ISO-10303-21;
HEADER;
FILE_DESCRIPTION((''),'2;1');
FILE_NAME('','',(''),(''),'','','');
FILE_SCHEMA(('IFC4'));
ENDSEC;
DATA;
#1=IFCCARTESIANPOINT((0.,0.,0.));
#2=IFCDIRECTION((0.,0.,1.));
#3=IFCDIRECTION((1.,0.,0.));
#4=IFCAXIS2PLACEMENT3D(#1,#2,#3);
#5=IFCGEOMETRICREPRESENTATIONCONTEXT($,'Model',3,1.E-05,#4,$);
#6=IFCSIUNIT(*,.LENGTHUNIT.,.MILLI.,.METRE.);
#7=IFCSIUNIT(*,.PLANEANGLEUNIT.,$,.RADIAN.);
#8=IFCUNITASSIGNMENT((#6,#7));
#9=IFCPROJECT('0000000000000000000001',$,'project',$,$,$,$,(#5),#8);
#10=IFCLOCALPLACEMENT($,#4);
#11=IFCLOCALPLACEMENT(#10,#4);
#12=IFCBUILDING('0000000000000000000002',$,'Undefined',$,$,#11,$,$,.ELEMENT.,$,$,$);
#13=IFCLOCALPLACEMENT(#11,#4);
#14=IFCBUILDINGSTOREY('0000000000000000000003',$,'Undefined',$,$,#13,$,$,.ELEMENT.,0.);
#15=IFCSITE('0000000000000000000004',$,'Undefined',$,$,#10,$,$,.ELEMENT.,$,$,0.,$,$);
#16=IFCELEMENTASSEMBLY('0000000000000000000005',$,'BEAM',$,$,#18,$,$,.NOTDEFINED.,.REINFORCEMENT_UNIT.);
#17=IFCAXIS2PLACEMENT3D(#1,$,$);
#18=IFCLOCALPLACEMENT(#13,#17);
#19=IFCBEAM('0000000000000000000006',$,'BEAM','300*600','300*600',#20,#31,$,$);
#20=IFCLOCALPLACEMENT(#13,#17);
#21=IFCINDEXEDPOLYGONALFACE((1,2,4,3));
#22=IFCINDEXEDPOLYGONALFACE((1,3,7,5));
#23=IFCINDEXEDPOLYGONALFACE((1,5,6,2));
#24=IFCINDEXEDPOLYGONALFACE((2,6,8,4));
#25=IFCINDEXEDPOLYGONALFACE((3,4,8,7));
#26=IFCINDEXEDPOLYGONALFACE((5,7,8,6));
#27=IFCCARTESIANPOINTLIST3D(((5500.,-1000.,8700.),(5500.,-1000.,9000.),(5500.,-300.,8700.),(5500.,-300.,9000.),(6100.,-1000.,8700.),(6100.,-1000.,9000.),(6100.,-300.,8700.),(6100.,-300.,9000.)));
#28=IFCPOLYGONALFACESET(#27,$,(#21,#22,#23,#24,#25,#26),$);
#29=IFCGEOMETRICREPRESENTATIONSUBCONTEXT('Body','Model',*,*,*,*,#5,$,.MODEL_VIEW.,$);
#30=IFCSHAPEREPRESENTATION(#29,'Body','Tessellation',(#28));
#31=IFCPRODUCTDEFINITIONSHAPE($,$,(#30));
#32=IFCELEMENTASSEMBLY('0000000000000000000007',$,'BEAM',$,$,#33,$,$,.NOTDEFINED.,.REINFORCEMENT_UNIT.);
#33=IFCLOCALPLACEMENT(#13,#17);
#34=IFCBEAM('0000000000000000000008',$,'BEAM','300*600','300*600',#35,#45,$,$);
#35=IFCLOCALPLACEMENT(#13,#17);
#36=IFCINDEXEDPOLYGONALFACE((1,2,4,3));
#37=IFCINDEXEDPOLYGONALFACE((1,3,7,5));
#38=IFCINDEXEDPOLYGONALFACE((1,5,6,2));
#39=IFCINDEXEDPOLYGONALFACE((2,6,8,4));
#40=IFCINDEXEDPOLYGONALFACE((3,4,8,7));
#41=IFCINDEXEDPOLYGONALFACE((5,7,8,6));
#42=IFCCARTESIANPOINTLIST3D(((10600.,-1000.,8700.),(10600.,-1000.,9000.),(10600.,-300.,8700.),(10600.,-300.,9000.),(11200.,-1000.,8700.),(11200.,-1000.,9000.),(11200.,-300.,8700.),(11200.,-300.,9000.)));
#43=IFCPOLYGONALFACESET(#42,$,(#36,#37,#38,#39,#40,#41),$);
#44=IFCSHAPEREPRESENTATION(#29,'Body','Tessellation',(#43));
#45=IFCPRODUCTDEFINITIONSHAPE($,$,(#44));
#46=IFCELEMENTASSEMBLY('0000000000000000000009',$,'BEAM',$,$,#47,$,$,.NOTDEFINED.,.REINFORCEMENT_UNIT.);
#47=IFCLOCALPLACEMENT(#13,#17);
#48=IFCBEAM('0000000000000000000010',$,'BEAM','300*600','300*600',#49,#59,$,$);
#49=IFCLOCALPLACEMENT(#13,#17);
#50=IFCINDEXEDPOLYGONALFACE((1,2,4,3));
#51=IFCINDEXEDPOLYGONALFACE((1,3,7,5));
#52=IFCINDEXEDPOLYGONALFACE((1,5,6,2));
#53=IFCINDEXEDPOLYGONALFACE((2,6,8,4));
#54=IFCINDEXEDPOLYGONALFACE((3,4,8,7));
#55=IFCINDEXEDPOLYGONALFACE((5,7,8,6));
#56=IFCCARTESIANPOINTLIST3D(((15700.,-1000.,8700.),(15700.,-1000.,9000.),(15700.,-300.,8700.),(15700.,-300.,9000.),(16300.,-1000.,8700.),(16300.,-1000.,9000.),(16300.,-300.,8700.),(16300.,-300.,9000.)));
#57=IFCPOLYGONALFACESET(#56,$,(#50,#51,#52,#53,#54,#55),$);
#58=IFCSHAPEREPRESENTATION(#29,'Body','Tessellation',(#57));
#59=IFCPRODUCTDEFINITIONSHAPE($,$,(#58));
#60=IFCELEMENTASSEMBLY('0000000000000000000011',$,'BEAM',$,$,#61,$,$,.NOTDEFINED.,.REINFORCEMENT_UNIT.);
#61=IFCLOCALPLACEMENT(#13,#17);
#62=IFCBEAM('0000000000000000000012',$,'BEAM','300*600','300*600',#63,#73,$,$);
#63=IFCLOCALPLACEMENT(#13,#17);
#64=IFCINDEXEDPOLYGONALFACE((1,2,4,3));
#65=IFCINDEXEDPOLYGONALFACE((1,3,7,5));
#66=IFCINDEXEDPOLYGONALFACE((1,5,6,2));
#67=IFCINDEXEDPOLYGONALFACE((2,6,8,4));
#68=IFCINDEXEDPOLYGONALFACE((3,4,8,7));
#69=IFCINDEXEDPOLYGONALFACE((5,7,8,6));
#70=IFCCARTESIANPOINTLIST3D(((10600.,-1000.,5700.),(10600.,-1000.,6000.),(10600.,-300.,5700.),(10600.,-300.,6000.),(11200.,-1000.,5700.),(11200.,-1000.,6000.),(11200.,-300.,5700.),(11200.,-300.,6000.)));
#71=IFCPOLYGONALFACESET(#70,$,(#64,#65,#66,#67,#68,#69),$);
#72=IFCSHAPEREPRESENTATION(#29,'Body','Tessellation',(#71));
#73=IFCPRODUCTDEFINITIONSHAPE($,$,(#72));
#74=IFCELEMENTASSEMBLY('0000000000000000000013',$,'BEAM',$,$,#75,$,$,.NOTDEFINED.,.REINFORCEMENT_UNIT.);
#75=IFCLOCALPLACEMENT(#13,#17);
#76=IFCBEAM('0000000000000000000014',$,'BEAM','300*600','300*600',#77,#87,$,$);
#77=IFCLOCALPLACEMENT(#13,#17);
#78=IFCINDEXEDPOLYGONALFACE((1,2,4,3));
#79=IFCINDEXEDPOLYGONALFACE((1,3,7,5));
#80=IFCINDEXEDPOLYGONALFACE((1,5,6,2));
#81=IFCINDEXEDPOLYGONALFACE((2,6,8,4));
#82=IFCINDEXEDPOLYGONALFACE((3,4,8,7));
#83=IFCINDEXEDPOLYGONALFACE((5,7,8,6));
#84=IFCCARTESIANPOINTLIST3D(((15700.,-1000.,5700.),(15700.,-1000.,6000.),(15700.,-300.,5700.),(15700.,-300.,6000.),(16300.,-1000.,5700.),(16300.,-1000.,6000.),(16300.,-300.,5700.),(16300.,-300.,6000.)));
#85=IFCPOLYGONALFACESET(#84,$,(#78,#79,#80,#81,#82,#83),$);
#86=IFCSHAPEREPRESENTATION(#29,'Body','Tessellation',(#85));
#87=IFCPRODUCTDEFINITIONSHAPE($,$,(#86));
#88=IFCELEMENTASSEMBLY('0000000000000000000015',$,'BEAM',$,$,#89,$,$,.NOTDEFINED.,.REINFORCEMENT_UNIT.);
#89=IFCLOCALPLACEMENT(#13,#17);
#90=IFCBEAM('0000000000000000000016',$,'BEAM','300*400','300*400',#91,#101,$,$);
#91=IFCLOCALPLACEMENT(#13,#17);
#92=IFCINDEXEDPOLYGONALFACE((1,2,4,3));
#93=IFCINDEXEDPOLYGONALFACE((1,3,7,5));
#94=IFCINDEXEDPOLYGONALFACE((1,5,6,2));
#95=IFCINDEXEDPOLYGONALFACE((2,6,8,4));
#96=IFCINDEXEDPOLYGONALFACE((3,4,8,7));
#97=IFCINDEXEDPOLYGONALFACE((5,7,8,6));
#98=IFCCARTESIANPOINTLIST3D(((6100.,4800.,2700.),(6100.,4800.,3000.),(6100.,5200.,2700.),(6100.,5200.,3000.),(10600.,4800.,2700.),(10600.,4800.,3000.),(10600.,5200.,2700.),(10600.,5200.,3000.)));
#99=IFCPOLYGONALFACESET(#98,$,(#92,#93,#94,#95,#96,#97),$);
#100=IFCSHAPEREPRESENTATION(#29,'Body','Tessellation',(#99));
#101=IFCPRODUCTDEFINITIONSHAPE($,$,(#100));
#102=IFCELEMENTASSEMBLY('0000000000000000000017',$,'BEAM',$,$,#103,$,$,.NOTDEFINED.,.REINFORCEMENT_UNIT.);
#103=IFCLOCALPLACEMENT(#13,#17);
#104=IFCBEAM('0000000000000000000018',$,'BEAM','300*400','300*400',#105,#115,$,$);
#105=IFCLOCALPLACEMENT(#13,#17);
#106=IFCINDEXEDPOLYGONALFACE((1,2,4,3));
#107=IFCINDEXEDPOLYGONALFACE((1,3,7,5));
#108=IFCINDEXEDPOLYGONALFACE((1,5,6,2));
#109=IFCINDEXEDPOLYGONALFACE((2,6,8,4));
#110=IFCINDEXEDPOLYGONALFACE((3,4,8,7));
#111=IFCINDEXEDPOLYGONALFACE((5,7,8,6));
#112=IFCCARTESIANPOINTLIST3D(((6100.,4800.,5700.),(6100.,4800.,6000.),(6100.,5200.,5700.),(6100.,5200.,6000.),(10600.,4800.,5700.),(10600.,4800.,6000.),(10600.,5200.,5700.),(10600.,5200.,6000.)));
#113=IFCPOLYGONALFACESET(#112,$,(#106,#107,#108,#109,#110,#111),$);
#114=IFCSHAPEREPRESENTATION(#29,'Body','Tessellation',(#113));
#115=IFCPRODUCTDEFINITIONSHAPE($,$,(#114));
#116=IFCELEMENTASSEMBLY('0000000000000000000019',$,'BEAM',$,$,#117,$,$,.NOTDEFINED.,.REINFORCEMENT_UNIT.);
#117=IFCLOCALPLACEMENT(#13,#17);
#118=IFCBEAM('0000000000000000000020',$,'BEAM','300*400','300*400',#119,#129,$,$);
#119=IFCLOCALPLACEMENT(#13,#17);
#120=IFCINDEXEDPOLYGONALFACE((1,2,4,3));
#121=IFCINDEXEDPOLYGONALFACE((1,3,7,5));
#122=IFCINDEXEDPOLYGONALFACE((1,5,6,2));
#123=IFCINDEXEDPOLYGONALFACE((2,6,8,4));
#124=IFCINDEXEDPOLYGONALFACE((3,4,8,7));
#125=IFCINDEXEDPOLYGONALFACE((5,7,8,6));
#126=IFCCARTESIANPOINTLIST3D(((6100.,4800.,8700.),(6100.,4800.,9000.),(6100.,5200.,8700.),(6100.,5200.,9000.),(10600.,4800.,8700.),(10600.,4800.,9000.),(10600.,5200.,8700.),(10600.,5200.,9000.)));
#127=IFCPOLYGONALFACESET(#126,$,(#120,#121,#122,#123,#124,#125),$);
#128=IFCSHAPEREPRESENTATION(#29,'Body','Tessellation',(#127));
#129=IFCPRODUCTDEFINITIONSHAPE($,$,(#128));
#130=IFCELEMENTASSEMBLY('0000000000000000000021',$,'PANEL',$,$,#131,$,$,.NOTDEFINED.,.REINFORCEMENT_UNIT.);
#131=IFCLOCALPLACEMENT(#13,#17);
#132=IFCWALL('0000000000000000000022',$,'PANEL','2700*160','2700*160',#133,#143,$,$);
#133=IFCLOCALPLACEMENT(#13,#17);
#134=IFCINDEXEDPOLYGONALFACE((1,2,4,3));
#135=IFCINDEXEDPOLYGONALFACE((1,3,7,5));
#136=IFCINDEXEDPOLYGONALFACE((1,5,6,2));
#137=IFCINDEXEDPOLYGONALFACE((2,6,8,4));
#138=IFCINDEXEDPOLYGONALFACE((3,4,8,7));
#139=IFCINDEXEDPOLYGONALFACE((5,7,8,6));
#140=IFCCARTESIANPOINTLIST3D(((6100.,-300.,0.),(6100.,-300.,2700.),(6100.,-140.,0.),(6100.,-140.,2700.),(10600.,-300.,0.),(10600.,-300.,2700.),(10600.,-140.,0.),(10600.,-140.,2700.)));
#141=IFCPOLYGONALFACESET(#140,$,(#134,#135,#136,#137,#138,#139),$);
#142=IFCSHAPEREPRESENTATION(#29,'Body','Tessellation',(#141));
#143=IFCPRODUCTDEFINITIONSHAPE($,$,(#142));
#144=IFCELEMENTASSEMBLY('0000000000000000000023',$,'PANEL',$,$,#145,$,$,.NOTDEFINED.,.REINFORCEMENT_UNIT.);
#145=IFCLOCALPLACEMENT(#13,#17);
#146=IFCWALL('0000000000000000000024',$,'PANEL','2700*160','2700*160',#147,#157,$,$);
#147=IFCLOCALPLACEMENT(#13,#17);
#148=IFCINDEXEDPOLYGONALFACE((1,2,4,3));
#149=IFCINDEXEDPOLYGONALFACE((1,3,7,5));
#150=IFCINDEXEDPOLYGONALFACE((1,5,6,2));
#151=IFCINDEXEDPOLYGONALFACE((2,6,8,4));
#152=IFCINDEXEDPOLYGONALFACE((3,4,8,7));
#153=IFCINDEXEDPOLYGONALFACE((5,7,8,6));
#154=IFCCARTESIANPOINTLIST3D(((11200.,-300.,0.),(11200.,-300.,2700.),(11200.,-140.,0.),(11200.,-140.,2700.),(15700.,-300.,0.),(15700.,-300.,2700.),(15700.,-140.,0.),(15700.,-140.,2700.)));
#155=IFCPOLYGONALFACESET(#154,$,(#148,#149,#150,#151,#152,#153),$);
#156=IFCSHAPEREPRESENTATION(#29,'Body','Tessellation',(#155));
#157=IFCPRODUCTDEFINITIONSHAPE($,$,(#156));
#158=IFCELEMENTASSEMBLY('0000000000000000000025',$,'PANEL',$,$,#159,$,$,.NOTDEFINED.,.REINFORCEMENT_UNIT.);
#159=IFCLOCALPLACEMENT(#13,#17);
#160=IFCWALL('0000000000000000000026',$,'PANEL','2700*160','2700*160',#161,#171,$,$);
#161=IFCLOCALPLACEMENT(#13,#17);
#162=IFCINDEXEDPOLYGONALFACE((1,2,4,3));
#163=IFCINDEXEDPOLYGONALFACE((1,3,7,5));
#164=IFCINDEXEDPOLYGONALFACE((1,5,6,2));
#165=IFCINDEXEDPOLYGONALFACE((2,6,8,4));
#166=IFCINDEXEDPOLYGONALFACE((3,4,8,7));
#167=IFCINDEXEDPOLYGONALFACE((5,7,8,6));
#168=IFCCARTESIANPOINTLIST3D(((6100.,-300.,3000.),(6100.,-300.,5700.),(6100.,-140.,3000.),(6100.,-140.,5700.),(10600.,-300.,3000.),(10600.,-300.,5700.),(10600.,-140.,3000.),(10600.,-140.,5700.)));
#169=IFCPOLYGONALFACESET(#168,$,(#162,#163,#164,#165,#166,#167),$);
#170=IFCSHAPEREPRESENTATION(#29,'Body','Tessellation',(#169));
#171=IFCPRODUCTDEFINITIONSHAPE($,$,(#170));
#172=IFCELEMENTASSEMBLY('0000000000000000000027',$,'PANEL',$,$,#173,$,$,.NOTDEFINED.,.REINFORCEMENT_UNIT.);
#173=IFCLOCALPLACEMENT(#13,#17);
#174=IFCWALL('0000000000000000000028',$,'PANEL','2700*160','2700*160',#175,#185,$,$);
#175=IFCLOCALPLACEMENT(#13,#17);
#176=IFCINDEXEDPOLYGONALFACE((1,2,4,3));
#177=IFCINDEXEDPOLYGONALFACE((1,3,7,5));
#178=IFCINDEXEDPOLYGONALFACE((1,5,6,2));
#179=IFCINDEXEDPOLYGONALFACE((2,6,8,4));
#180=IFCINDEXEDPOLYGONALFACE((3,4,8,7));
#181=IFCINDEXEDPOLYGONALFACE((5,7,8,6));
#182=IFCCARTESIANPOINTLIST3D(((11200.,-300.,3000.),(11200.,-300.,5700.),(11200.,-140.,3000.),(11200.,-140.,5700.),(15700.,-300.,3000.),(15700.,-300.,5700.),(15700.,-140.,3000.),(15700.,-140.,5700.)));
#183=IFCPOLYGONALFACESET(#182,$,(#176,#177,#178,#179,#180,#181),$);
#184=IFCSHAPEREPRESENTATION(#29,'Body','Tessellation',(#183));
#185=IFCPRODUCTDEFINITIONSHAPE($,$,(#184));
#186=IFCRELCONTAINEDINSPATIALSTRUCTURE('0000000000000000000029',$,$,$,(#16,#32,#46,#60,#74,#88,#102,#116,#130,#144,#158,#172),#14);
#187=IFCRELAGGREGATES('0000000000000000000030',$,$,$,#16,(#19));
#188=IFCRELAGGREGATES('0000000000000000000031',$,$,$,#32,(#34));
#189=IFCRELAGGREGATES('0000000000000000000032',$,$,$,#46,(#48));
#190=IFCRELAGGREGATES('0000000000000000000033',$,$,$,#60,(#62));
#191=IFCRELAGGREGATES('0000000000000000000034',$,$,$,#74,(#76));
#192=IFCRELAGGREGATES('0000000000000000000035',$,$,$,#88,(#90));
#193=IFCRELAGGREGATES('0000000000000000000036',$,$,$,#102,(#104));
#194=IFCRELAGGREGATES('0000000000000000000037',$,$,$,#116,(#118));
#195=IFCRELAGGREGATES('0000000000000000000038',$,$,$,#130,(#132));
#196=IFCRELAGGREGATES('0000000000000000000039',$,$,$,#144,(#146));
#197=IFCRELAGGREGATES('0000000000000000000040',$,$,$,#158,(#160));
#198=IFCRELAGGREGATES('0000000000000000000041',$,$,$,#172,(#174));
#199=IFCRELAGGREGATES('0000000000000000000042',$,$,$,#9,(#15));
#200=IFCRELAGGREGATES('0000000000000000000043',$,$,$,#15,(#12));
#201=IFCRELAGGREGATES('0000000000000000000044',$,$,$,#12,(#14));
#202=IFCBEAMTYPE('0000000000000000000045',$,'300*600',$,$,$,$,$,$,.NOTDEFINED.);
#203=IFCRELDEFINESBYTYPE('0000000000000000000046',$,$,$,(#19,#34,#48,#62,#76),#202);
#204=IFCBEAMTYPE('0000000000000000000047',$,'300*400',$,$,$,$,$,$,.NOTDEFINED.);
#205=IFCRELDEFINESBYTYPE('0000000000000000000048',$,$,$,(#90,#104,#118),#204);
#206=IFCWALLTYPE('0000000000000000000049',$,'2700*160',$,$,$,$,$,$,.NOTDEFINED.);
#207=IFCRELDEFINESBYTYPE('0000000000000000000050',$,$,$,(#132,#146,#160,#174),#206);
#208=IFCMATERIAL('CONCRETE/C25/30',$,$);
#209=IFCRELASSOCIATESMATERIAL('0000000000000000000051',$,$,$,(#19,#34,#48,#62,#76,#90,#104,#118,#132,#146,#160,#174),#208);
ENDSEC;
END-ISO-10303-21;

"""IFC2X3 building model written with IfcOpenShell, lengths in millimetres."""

from ifc_helpers import new_model, si_unit, frame, frame_2d, origin_with_axes, origin_2d_with_axis, place, context, subcontext, project, spatial, rectangle, extrude, material, type_object, element, aggregate, save


model = new_model("IFC2X3")

# Units and contexts
model_context = context("Model", 3, precision=1e-05, world=origin_with_axes())
body_context = subcontext(model_context, "Body", "Model", "MODEL_VIEW")
ifc_project = project(units=[si_unit("LENGTHUNIT", "METRE", prefix="MILLI"), si_unit("PLANEANGLEUNIT", "RADIAN")], contexts=[model_context])

# Site, building, storey
site_placement = place(None, origin_with_axes())
site = spatial("IfcSite", under=ifc_project, at=site_placement, Name="Undefined", CompositionType="ELEMENT", RefElevation=0.0)
building_placement = place(site_placement, origin_with_axes())
building = spatial("IfcBuilding", under=site, at=building_placement, Name="Undefined", CompositionType="ELEMENT")
storey_placement = place(building_placement, origin_with_axes())
storey = spatial("IfcBuildingStorey", under=building, at=storey_placement, Name="Undefined", CompositionType="ELEMENT", Elevation=0.0)

# Shared definitions
ifc_material = material(Name="CONCRETE/C25/30")

# Element assemblies, beams
beam_type_1 = type_object("IfcBeamType", Name="300*600", PredefinedType="NOTDEFINED")
assembly_1_placement = place(storey_placement, origin_with_axes())
assembly_1 = element("IfcElementAssembly", 1, at=assembly_1_placement, inside=storey, Name="BEAM", AssemblyPlace="NOTDEFINED", PredefinedType="REINFORCEMENT_UNIT")
beam_1_placement = place(assembly_1_placement, frame((5800.0, -300.0, 8850.0), z_axis=(0.0, 0.0, 1.0), x_axis=(0.0, -1.0, 0.0)))
beam_1 = element("IfcBeam", 2, at=beam_1_placement, type_object=beam_type_1, material=ifc_material, Name="BEAM", Description="300*600", ObjectType="300*600", context=body_context, shape_type="SweptSolid", body=[
    extrude(rectangle(XDim=600.0, YDim=300.0, at=origin_2d_with_axis()), frame((700.0, 0.0, 0.0), z_axis=(-1.0, 0.0, 0.0), x_axis=(0.0, -1.0, 0.0)), (0.0, 0.0, 1.0), 700.0),
])
aggregate(assembly_1, [beam_1])
assembly_2_placement = place(storey_placement, origin_with_axes())
assembly_2 = element("IfcElementAssembly", 3, at=assembly_2_placement, inside=storey, Name="BEAM", AssemblyPlace="NOTDEFINED", PredefinedType="REINFORCEMENT_UNIT")
beam_2_placement = place(assembly_2_placement, frame((10900.0, -300.0, 8850.0), z_axis=(0.0, 0.0, 1.0), x_axis=(0.0, -1.0, 0.0)))
beam_2 = element("IfcBeam", 4, at=beam_2_placement, type_object=beam_type_1, material=ifc_material, Name="BEAM", Description="300*600", ObjectType="300*600", context=body_context, shape_type="SweptSolid", body=[
    extrude(rectangle(XDim=600.0, YDim=300.0, at=origin_2d_with_axis()), frame((700.0, 0.0, 0.0), z_axis=(-1.0, 0.0, 0.0), x_axis=(0.0, -1.0, 0.0)), (0.0, 0.0, 1.0), 700.0),
])
aggregate(assembly_2, [beam_2])
assembly_3_placement = place(storey_placement, origin_with_axes())
assembly_3 = element("IfcElementAssembly", 5, at=assembly_3_placement, inside=storey, Name="BEAM", AssemblyPlace="NOTDEFINED", PredefinedType="REINFORCEMENT_UNIT")
beam_3_placement = place(assembly_3_placement, frame((16000.0, -300.0, 8850.0), z_axis=(0.0, 0.0, 1.0), x_axis=(0.0, -1.0, 0.0)))
beam_3 = element("IfcBeam", 6, at=beam_3_placement, type_object=beam_type_1, material=ifc_material, Name="BEAM", Description="300*600", ObjectType="300*600", context=body_context, shape_type="SweptSolid", body=[
    extrude(rectangle(XDim=600.0, YDim=300.0, at=origin_2d_with_axis()), frame((700.0, 0.0, 0.0), z_axis=(-1.0, 0.0, 0.0), x_axis=(0.0, -1.0, 0.0)), (0.0, 0.0, 1.0), 700.0),
])
aggregate(assembly_3, [beam_3])
assembly_4_placement = place(storey_placement, origin_with_axes())
assembly_4 = element("IfcElementAssembly", 7, at=assembly_4_placement, inside=storey, Name="BEAM", AssemblyPlace="NOTDEFINED", PredefinedType="REINFORCEMENT_UNIT")
beam_4_placement = place(assembly_4_placement, frame((10900.0, -300.0, 5850.0), z_axis=(0.0, 0.0, 1.0), x_axis=(0.0, -1.0, 0.0)))
beam_4 = element("IfcBeam", 8, at=beam_4_placement, type_object=beam_type_1, material=ifc_material, Name="BEAM", Description="300*600", ObjectType="300*600", context=body_context, shape_type="SweptSolid", body=[
    extrude(rectangle(XDim=600.0, YDim=300.0, at=origin_2d_with_axis()), frame((700.0, 0.0, 0.0), z_axis=(-1.0, 0.0, 0.0), x_axis=(0.0, -1.0, 0.0)), (0.0, 0.0, 1.0), 700.0),
])
aggregate(assembly_4, [beam_4])
assembly_5_placement = place(storey_placement, origin_with_axes())
assembly_5 = element("IfcElementAssembly", 9, at=assembly_5_placement, inside=storey, Name="BEAM", AssemblyPlace="NOTDEFINED", PredefinedType="REINFORCEMENT_UNIT")
beam_5_placement = place(assembly_5_placement, frame((16000.0, -300.0, 5850.0), z_axis=(0.0, 0.0, 1.0), x_axis=(0.0, -1.0, 0.0)))
beam_5 = element("IfcBeam", 10, at=beam_5_placement, type_object=beam_type_1, material=ifc_material, Name="BEAM", Description="300*600", ObjectType="300*600", context=body_context, shape_type="SweptSolid", body=[
    extrude(rectangle(XDim=600.0, YDim=300.0, at=origin_2d_with_axis()), frame((700.0, 0.0, 0.0), z_axis=(-1.0, 0.0, 0.0), x_axis=(0.0, -1.0, 0.0)), (0.0, 0.0, 1.0), 700.0),
])
aggregate(assembly_5, [beam_5])
assembly_6_placement = place(storey_placement, origin_with_axes())
assembly_6 = element("IfcElementAssembly", 11, at=assembly_6_placement, inside=storey, Name="BEAM", AssemblyPlace="NOTDEFINED", PredefinedType="REINFORCEMENT_UNIT")
beam_type_2 = type_object("IfcBeamType", Name="300*400", PredefinedType="NOTDEFINED")
beam_6_placement = place(assembly_6_placement, frame((10900.0, 5000.0, 2850.0), z_axis=(0.0, 0.0, 1.0), x_axis=(-1.0, 0.0, 0.0)))
beam_6 = element("IfcBeam", 12, at=beam_6_placement, type_object=beam_type_2, material=ifc_material, Name="BEAM", Description="300*400", ObjectType="300*400", context=body_context, shape_type="SweptSolid", body=[
    extrude(rectangle(XDim=400.0, YDim=300.0, at=origin_2d_with_axis()), frame((4800.0, 0.0, 0.0), z_axis=(-1.0, 0.0, 0.0), x_axis=(0.0, -1.0, 0.0)), (0.0, 0.0, 1.0), 4500.0),
])
aggregate(assembly_6, [beam_6])
assembly_7_placement = place(storey_placement, origin_with_axes())
assembly_7 = element("IfcElementAssembly", 13, at=assembly_7_placement, inside=storey, Name="BEAM", AssemblyPlace="NOTDEFINED", PredefinedType="REINFORCEMENT_UNIT")
beam_7_placement = place(assembly_7_placement, frame((10900.0, 5000.0, 5850.0), z_axis=(0.0, 0.0, 1.0), x_axis=(-1.0, 0.0, 0.0)))
beam_7 = element("IfcBeam", 14, at=beam_7_placement, type_object=beam_type_2, material=ifc_material, Name="BEAM", Description="300*400", ObjectType="300*400", context=body_context, shape_type="SweptSolid", body=[
    extrude(rectangle(XDim=400.0, YDim=300.0, at=origin_2d_with_axis()), frame((4800.0, 0.0, 0.0), z_axis=(-1.0, 0.0, 0.0), x_axis=(0.0, -1.0, 0.0)), (0.0, 0.0, 1.0), 4500.0),
])
aggregate(assembly_7, [beam_7])
assembly_8_placement = place(storey_placement, origin_with_axes())
assembly_8 = element("IfcElementAssembly", 15, at=assembly_8_placement, inside=storey, Name="BEAM", AssemblyPlace="NOTDEFINED", PredefinedType="REINFORCEMENT_UNIT")
beam_8_placement = place(assembly_8_placement, frame((10900.0, 5000.0, 8850.0), z_axis=(0.0, 0.0, 1.0), x_axis=(-1.0, 0.0, 0.0)))
beam_8 = element("IfcBeam", 16, at=beam_8_placement, type_object=beam_type_2, material=ifc_material, Name="BEAM", Description="300*400", ObjectType="300*400", context=body_context, shape_type="SweptSolid", body=[
    extrude(rectangle(XDim=400.0, YDim=300.0, at=origin_2d_with_axis()), frame((4800.0, 0.0, 0.0), z_axis=(-1.0, 0.0, 0.0), x_axis=(0.0, -1.0, 0.0)), (0.0, 0.0, 1.0), 4500.0),
])
aggregate(assembly_8, [beam_8])

# Element assemblies, walls
assembly_9_placement = place(storey_placement, origin_with_axes())
assembly_9 = element("IfcElementAssembly", 17, at=assembly_9_placement, inside=storey, Name="PANEL", AssemblyPlace="NOTDEFINED", PredefinedType="REINFORCEMENT_UNIT")
wall_type = type_object("IfcWallType", Name="2700*160", PredefinedType="NOTDEFINED")
wall_1_placement = place(assembly_9_placement, frame((6100.0, -220.0, 0.0), z_axis=(0.0, 0.0, 1.0), x_axis=(1.0, 0.0, 0.0)))
wall_1 = element("IfcWall", 18, at=wall_1_placement, type_object=wall_type, material=ifc_material, Name="PANEL", Description="2700*160", ObjectType="2700*160", context=body_context, shape_type="SweptSolid", body=[
    extrude(rectangle(XDim=4500.0, YDim=160.0, at=frame_2d((0.0, 2250.0), x_axis=(0.0, -1.0))), frame((0.0, 0.0, 0.0), z_axis=(0.0, 0.0, 1.0), x_axis=(0.0, -1.0, 0.0)), (0.0, 0.0, 1.0), 2700.0),
])
aggregate(assembly_9, [wall_1])
assembly_10_placement = place(storey_placement, origin_with_axes())
assembly_10 = element("IfcElementAssembly", 19, at=assembly_10_placement, inside=storey, Name="PANEL", AssemblyPlace="NOTDEFINED", PredefinedType="REINFORCEMENT_UNIT")
wall_2_placement = place(assembly_10_placement, frame((11200.0, -220.0, 0.0), z_axis=(0.0, 0.0, 1.0), x_axis=(1.0, 0.0, 0.0)))
wall_2 = element("IfcWall", 20, at=wall_2_placement, type_object=wall_type, material=ifc_material, Name="PANEL", Description="2700*160", ObjectType="2700*160", context=body_context, shape_type="SweptSolid", body=[
    extrude(rectangle(XDim=4500.0, YDim=160.0, at=frame_2d((0.0, 2250.0), x_axis=(0.0, -1.0))), frame((0.0, 0.0, 0.0), z_axis=(0.0, 0.0, 1.0), x_axis=(0.0, -1.0, 0.0)), (0.0, 0.0, 1.0), 2700.0),
])
aggregate(assembly_10, [wall_2])
assembly_11_placement = place(storey_placement, origin_with_axes())
assembly_11 = element("IfcElementAssembly", 21, at=assembly_11_placement, inside=storey, Name="PANEL", AssemblyPlace="NOTDEFINED", PredefinedType="REINFORCEMENT_UNIT")
wall_3_placement = place(assembly_11_placement, frame((6100.0, -220.0, 3000.0), z_axis=(0.0, 0.0, 1.0), x_axis=(1.0, 0.0, 0.0)))
wall_3 = element("IfcWall", 22, at=wall_3_placement, type_object=wall_type, material=ifc_material, Name="PANEL", Description="2700*160", ObjectType="2700*160", context=body_context, shape_type="SweptSolid", body=[
    extrude(rectangle(XDim=4500.0, YDim=160.0, at=frame_2d((0.0, 2250.0), x_axis=(0.0, -1.0))), frame((0.0, 0.0, 0.0), z_axis=(0.0, 0.0, 1.0), x_axis=(0.0, -1.0, 0.0)), (0.0, 0.0, 1.0), 2700.0),
])
aggregate(assembly_11, [wall_3])
assembly_12_placement = place(storey_placement, origin_with_axes())
assembly_12 = element("IfcElementAssembly", 23, at=assembly_12_placement, inside=storey, Name="PANEL", AssemblyPlace="NOTDEFINED", PredefinedType="REINFORCEMENT_UNIT")
wall_4_placement = place(assembly_12_placement, frame((11200.0, -220.0, 3000.0), z_axis=(0.0, 0.0, 1.0), x_axis=(1.0, 0.0, 0.0)))
wall_4 = element("IfcWall", 24, at=wall_4_placement, type_object=wall_type, material=ifc_material, Name="PANEL", Description="2700*160", ObjectType="2700*160", context=body_context, shape_type="SweptSolid", body=[
    extrude(rectangle(XDim=4500.0, YDim=160.0, at=frame_2d((0.0, 2250.0), x_axis=(0.0, -1.0))), frame((0.0, 0.0, 0.0), z_axis=(0.0, 0.0, 1.0), x_axis=(0.0, -1.0, 0.0)), (0.0, 0.0, 1.0), 2700.0),
])
aggregate(assembly_12, [wall_4])

save(model, "model.ifc")
